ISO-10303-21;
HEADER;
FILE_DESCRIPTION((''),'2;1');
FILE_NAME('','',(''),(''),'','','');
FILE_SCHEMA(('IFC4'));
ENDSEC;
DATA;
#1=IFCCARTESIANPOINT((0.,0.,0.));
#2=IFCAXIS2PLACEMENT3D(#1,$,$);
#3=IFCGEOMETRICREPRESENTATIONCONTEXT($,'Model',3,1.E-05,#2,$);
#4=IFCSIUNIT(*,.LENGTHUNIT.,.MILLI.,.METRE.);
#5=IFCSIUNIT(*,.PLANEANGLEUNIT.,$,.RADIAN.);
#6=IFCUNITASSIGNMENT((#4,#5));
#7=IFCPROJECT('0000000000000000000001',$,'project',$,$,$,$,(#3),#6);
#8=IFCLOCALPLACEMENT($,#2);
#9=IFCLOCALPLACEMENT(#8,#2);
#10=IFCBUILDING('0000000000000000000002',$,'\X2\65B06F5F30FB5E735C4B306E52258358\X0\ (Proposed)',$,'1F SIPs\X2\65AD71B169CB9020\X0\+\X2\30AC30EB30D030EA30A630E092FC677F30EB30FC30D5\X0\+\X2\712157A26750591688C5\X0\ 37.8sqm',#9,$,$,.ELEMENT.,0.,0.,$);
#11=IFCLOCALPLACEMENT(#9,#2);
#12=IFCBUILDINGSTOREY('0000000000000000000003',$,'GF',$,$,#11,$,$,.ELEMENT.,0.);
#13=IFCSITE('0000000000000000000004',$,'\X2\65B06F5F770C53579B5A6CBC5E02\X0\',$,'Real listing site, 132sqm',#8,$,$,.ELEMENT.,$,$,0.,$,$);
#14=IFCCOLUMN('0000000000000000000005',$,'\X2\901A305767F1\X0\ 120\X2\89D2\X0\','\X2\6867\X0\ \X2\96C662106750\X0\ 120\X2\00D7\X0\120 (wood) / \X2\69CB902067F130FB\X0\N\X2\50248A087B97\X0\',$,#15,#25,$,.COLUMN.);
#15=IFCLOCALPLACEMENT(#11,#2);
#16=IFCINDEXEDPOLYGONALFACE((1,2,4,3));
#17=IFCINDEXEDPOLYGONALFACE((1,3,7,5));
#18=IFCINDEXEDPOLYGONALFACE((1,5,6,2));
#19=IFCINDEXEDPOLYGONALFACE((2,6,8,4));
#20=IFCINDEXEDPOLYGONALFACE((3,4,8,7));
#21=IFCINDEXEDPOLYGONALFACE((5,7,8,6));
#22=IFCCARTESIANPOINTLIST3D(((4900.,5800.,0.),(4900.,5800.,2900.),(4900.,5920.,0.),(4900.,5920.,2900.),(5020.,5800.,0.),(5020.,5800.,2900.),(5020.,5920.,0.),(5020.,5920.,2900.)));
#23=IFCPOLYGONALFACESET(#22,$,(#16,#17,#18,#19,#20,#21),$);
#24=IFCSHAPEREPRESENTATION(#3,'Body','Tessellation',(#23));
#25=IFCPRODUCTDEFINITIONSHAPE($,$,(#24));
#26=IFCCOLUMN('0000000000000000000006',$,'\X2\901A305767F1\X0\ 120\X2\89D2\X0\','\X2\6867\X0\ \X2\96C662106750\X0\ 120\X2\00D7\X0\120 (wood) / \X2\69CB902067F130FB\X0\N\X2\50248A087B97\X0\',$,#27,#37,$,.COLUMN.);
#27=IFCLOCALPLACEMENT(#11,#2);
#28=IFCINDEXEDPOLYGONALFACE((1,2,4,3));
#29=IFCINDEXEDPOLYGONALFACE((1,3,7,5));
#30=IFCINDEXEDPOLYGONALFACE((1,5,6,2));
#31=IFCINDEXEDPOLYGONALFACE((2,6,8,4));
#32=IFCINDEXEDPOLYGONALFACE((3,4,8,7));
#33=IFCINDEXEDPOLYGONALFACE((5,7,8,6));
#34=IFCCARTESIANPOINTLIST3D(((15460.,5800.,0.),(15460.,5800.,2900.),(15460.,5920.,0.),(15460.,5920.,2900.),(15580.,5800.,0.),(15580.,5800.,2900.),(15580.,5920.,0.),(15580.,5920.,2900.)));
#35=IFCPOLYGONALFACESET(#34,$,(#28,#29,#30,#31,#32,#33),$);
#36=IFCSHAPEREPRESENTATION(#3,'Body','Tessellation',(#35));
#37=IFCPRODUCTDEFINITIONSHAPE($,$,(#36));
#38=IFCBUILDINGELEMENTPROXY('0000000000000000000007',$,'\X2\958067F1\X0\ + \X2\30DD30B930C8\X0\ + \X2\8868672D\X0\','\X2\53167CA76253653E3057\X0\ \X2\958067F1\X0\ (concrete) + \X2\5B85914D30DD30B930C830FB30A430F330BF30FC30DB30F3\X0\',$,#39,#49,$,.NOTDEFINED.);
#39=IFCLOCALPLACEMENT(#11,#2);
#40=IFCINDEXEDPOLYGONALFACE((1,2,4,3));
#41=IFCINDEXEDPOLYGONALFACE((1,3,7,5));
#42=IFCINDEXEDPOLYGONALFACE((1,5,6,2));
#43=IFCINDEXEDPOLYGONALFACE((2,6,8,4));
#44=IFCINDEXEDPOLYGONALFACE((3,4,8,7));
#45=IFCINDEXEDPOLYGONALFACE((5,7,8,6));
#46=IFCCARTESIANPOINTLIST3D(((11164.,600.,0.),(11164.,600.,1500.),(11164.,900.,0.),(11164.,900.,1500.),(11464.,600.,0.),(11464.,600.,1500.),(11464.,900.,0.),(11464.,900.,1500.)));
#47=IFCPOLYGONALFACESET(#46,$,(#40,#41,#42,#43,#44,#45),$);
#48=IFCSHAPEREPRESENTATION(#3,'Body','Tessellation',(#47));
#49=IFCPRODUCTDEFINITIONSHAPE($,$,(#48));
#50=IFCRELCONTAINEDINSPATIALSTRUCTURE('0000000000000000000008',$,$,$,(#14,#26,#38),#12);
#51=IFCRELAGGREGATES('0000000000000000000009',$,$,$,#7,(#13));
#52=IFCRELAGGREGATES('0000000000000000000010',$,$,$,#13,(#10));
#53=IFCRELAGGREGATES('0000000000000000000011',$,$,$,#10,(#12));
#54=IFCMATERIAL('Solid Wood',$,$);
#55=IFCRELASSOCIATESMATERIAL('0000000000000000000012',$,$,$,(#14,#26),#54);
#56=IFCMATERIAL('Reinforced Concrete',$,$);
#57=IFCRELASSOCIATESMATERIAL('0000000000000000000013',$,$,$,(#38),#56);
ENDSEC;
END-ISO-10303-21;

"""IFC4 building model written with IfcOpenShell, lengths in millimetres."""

from ifc_helpers import new_model, si_unit, frame, frame_2d, origin, place, context, project, spatial, rectangle, extrude, material, element, save


model = new_model("IFC4")

# Units and contexts
model_context = context("Model", 3, precision=1e-05, world=origin())
ifc_project = project(units=[si_unit("LENGTHUNIT", "METRE", prefix="MILLI"), si_unit("PLANEANGLEUNIT", "RADIAN")], contexts=[model_context])

# Site, building, storey
site_placement = place(None, origin())
site = spatial("IfcSite", under=ifc_project, at=site_placement, Name="新潟県南魚沼市", ObjectType="Real listing site, 132sqm", CompositionType="ELEMENT", RefElevation=0.0)
building_placement = place(site_placement, origin())
building = spatial("IfcBuilding", under=site, at=building_placement, Name="新潟・平屋の別荘 (Proposed)", ObjectType="1F SIPs断熱構造+ガルバリウム鋼板ルーフ+無垢材外装 37.8sqm", CompositionType="ELEMENT", ElevationOfRefHeight=0.0, ElevationOfTerrain=0.0)
storey_placement = place(building_placement, origin())
storey = spatial("IfcBuildingStorey", under=building, at=storey_placement, Name="GF", CompositionType="ELEMENT", Elevation=0.0)

# Columns
ifc_material_1 = material(Name="Solid Wood")
column_1_placement = place(storey_placement, frame((2450.0, 2900.0, 0.0)))
element("IfcColumn", 1, at=column_1_placement, inside=storey, material=ifc_material_1, Name="通し柱 120角", Description="桧 集成材 120×120 (wood) / 構造柱・N値計算", PredefinedType="COLUMN", context=model_context, shape_type="SweptSolid", body=[
    extrude(rectangle(XDim=120.0, YDim=120.0, at=frame_2d((60.0, 60.0))), frame((2450.0, 2900.0, 0.0)), (0.0, 0.0, 1.0), 2900.0),
])
column_2_placement = place(storey_placement, frame((7730.0, 2900.0, 0.0)))
element("IfcColumn", 2, at=column_2_placement, inside=storey, material=ifc_material_1, Name="通し柱 120角", Description="桧 集成材 120×120 (wood) / 構造柱・N値計算", PredefinedType="COLUMN", context=model_context, shape_type="SweptSolid", body=[
    extrude(rectangle(XDim=120.0, YDim=120.0, at=frame_2d((60.0, 60.0))), frame((7730.0, 2900.0, 0.0)), (0.0, 0.0, 1.0), 2900.0),
])

# Shared definitions
ifc_material_2 = material(Name="Reinforced Concrete")

# Building element proxy
proxy_placement = place(storey_placement, frame((5582.0, 300.0, 0.0)))
element("IfcBuildingElementProxy", 3, at=proxy_placement, inside=storey, material=ifc_material_2, Name="門柱 + ポスト + 表札", Description="化粧打放し 門柱 (concrete) + 宅配ポスト・インターホン", PredefinedType="NOTDEFINED", context=model_context, shape_type="SweptSolid", body=[
    extrude(rectangle(XDim=300.0, YDim=300.0, at=frame_2d((150.0, 150.0))), frame((5582.0, 300.0, 0.0)), (0.0, 0.0, 1.0), 1500.0),
])

save(model, "model.ifc")
